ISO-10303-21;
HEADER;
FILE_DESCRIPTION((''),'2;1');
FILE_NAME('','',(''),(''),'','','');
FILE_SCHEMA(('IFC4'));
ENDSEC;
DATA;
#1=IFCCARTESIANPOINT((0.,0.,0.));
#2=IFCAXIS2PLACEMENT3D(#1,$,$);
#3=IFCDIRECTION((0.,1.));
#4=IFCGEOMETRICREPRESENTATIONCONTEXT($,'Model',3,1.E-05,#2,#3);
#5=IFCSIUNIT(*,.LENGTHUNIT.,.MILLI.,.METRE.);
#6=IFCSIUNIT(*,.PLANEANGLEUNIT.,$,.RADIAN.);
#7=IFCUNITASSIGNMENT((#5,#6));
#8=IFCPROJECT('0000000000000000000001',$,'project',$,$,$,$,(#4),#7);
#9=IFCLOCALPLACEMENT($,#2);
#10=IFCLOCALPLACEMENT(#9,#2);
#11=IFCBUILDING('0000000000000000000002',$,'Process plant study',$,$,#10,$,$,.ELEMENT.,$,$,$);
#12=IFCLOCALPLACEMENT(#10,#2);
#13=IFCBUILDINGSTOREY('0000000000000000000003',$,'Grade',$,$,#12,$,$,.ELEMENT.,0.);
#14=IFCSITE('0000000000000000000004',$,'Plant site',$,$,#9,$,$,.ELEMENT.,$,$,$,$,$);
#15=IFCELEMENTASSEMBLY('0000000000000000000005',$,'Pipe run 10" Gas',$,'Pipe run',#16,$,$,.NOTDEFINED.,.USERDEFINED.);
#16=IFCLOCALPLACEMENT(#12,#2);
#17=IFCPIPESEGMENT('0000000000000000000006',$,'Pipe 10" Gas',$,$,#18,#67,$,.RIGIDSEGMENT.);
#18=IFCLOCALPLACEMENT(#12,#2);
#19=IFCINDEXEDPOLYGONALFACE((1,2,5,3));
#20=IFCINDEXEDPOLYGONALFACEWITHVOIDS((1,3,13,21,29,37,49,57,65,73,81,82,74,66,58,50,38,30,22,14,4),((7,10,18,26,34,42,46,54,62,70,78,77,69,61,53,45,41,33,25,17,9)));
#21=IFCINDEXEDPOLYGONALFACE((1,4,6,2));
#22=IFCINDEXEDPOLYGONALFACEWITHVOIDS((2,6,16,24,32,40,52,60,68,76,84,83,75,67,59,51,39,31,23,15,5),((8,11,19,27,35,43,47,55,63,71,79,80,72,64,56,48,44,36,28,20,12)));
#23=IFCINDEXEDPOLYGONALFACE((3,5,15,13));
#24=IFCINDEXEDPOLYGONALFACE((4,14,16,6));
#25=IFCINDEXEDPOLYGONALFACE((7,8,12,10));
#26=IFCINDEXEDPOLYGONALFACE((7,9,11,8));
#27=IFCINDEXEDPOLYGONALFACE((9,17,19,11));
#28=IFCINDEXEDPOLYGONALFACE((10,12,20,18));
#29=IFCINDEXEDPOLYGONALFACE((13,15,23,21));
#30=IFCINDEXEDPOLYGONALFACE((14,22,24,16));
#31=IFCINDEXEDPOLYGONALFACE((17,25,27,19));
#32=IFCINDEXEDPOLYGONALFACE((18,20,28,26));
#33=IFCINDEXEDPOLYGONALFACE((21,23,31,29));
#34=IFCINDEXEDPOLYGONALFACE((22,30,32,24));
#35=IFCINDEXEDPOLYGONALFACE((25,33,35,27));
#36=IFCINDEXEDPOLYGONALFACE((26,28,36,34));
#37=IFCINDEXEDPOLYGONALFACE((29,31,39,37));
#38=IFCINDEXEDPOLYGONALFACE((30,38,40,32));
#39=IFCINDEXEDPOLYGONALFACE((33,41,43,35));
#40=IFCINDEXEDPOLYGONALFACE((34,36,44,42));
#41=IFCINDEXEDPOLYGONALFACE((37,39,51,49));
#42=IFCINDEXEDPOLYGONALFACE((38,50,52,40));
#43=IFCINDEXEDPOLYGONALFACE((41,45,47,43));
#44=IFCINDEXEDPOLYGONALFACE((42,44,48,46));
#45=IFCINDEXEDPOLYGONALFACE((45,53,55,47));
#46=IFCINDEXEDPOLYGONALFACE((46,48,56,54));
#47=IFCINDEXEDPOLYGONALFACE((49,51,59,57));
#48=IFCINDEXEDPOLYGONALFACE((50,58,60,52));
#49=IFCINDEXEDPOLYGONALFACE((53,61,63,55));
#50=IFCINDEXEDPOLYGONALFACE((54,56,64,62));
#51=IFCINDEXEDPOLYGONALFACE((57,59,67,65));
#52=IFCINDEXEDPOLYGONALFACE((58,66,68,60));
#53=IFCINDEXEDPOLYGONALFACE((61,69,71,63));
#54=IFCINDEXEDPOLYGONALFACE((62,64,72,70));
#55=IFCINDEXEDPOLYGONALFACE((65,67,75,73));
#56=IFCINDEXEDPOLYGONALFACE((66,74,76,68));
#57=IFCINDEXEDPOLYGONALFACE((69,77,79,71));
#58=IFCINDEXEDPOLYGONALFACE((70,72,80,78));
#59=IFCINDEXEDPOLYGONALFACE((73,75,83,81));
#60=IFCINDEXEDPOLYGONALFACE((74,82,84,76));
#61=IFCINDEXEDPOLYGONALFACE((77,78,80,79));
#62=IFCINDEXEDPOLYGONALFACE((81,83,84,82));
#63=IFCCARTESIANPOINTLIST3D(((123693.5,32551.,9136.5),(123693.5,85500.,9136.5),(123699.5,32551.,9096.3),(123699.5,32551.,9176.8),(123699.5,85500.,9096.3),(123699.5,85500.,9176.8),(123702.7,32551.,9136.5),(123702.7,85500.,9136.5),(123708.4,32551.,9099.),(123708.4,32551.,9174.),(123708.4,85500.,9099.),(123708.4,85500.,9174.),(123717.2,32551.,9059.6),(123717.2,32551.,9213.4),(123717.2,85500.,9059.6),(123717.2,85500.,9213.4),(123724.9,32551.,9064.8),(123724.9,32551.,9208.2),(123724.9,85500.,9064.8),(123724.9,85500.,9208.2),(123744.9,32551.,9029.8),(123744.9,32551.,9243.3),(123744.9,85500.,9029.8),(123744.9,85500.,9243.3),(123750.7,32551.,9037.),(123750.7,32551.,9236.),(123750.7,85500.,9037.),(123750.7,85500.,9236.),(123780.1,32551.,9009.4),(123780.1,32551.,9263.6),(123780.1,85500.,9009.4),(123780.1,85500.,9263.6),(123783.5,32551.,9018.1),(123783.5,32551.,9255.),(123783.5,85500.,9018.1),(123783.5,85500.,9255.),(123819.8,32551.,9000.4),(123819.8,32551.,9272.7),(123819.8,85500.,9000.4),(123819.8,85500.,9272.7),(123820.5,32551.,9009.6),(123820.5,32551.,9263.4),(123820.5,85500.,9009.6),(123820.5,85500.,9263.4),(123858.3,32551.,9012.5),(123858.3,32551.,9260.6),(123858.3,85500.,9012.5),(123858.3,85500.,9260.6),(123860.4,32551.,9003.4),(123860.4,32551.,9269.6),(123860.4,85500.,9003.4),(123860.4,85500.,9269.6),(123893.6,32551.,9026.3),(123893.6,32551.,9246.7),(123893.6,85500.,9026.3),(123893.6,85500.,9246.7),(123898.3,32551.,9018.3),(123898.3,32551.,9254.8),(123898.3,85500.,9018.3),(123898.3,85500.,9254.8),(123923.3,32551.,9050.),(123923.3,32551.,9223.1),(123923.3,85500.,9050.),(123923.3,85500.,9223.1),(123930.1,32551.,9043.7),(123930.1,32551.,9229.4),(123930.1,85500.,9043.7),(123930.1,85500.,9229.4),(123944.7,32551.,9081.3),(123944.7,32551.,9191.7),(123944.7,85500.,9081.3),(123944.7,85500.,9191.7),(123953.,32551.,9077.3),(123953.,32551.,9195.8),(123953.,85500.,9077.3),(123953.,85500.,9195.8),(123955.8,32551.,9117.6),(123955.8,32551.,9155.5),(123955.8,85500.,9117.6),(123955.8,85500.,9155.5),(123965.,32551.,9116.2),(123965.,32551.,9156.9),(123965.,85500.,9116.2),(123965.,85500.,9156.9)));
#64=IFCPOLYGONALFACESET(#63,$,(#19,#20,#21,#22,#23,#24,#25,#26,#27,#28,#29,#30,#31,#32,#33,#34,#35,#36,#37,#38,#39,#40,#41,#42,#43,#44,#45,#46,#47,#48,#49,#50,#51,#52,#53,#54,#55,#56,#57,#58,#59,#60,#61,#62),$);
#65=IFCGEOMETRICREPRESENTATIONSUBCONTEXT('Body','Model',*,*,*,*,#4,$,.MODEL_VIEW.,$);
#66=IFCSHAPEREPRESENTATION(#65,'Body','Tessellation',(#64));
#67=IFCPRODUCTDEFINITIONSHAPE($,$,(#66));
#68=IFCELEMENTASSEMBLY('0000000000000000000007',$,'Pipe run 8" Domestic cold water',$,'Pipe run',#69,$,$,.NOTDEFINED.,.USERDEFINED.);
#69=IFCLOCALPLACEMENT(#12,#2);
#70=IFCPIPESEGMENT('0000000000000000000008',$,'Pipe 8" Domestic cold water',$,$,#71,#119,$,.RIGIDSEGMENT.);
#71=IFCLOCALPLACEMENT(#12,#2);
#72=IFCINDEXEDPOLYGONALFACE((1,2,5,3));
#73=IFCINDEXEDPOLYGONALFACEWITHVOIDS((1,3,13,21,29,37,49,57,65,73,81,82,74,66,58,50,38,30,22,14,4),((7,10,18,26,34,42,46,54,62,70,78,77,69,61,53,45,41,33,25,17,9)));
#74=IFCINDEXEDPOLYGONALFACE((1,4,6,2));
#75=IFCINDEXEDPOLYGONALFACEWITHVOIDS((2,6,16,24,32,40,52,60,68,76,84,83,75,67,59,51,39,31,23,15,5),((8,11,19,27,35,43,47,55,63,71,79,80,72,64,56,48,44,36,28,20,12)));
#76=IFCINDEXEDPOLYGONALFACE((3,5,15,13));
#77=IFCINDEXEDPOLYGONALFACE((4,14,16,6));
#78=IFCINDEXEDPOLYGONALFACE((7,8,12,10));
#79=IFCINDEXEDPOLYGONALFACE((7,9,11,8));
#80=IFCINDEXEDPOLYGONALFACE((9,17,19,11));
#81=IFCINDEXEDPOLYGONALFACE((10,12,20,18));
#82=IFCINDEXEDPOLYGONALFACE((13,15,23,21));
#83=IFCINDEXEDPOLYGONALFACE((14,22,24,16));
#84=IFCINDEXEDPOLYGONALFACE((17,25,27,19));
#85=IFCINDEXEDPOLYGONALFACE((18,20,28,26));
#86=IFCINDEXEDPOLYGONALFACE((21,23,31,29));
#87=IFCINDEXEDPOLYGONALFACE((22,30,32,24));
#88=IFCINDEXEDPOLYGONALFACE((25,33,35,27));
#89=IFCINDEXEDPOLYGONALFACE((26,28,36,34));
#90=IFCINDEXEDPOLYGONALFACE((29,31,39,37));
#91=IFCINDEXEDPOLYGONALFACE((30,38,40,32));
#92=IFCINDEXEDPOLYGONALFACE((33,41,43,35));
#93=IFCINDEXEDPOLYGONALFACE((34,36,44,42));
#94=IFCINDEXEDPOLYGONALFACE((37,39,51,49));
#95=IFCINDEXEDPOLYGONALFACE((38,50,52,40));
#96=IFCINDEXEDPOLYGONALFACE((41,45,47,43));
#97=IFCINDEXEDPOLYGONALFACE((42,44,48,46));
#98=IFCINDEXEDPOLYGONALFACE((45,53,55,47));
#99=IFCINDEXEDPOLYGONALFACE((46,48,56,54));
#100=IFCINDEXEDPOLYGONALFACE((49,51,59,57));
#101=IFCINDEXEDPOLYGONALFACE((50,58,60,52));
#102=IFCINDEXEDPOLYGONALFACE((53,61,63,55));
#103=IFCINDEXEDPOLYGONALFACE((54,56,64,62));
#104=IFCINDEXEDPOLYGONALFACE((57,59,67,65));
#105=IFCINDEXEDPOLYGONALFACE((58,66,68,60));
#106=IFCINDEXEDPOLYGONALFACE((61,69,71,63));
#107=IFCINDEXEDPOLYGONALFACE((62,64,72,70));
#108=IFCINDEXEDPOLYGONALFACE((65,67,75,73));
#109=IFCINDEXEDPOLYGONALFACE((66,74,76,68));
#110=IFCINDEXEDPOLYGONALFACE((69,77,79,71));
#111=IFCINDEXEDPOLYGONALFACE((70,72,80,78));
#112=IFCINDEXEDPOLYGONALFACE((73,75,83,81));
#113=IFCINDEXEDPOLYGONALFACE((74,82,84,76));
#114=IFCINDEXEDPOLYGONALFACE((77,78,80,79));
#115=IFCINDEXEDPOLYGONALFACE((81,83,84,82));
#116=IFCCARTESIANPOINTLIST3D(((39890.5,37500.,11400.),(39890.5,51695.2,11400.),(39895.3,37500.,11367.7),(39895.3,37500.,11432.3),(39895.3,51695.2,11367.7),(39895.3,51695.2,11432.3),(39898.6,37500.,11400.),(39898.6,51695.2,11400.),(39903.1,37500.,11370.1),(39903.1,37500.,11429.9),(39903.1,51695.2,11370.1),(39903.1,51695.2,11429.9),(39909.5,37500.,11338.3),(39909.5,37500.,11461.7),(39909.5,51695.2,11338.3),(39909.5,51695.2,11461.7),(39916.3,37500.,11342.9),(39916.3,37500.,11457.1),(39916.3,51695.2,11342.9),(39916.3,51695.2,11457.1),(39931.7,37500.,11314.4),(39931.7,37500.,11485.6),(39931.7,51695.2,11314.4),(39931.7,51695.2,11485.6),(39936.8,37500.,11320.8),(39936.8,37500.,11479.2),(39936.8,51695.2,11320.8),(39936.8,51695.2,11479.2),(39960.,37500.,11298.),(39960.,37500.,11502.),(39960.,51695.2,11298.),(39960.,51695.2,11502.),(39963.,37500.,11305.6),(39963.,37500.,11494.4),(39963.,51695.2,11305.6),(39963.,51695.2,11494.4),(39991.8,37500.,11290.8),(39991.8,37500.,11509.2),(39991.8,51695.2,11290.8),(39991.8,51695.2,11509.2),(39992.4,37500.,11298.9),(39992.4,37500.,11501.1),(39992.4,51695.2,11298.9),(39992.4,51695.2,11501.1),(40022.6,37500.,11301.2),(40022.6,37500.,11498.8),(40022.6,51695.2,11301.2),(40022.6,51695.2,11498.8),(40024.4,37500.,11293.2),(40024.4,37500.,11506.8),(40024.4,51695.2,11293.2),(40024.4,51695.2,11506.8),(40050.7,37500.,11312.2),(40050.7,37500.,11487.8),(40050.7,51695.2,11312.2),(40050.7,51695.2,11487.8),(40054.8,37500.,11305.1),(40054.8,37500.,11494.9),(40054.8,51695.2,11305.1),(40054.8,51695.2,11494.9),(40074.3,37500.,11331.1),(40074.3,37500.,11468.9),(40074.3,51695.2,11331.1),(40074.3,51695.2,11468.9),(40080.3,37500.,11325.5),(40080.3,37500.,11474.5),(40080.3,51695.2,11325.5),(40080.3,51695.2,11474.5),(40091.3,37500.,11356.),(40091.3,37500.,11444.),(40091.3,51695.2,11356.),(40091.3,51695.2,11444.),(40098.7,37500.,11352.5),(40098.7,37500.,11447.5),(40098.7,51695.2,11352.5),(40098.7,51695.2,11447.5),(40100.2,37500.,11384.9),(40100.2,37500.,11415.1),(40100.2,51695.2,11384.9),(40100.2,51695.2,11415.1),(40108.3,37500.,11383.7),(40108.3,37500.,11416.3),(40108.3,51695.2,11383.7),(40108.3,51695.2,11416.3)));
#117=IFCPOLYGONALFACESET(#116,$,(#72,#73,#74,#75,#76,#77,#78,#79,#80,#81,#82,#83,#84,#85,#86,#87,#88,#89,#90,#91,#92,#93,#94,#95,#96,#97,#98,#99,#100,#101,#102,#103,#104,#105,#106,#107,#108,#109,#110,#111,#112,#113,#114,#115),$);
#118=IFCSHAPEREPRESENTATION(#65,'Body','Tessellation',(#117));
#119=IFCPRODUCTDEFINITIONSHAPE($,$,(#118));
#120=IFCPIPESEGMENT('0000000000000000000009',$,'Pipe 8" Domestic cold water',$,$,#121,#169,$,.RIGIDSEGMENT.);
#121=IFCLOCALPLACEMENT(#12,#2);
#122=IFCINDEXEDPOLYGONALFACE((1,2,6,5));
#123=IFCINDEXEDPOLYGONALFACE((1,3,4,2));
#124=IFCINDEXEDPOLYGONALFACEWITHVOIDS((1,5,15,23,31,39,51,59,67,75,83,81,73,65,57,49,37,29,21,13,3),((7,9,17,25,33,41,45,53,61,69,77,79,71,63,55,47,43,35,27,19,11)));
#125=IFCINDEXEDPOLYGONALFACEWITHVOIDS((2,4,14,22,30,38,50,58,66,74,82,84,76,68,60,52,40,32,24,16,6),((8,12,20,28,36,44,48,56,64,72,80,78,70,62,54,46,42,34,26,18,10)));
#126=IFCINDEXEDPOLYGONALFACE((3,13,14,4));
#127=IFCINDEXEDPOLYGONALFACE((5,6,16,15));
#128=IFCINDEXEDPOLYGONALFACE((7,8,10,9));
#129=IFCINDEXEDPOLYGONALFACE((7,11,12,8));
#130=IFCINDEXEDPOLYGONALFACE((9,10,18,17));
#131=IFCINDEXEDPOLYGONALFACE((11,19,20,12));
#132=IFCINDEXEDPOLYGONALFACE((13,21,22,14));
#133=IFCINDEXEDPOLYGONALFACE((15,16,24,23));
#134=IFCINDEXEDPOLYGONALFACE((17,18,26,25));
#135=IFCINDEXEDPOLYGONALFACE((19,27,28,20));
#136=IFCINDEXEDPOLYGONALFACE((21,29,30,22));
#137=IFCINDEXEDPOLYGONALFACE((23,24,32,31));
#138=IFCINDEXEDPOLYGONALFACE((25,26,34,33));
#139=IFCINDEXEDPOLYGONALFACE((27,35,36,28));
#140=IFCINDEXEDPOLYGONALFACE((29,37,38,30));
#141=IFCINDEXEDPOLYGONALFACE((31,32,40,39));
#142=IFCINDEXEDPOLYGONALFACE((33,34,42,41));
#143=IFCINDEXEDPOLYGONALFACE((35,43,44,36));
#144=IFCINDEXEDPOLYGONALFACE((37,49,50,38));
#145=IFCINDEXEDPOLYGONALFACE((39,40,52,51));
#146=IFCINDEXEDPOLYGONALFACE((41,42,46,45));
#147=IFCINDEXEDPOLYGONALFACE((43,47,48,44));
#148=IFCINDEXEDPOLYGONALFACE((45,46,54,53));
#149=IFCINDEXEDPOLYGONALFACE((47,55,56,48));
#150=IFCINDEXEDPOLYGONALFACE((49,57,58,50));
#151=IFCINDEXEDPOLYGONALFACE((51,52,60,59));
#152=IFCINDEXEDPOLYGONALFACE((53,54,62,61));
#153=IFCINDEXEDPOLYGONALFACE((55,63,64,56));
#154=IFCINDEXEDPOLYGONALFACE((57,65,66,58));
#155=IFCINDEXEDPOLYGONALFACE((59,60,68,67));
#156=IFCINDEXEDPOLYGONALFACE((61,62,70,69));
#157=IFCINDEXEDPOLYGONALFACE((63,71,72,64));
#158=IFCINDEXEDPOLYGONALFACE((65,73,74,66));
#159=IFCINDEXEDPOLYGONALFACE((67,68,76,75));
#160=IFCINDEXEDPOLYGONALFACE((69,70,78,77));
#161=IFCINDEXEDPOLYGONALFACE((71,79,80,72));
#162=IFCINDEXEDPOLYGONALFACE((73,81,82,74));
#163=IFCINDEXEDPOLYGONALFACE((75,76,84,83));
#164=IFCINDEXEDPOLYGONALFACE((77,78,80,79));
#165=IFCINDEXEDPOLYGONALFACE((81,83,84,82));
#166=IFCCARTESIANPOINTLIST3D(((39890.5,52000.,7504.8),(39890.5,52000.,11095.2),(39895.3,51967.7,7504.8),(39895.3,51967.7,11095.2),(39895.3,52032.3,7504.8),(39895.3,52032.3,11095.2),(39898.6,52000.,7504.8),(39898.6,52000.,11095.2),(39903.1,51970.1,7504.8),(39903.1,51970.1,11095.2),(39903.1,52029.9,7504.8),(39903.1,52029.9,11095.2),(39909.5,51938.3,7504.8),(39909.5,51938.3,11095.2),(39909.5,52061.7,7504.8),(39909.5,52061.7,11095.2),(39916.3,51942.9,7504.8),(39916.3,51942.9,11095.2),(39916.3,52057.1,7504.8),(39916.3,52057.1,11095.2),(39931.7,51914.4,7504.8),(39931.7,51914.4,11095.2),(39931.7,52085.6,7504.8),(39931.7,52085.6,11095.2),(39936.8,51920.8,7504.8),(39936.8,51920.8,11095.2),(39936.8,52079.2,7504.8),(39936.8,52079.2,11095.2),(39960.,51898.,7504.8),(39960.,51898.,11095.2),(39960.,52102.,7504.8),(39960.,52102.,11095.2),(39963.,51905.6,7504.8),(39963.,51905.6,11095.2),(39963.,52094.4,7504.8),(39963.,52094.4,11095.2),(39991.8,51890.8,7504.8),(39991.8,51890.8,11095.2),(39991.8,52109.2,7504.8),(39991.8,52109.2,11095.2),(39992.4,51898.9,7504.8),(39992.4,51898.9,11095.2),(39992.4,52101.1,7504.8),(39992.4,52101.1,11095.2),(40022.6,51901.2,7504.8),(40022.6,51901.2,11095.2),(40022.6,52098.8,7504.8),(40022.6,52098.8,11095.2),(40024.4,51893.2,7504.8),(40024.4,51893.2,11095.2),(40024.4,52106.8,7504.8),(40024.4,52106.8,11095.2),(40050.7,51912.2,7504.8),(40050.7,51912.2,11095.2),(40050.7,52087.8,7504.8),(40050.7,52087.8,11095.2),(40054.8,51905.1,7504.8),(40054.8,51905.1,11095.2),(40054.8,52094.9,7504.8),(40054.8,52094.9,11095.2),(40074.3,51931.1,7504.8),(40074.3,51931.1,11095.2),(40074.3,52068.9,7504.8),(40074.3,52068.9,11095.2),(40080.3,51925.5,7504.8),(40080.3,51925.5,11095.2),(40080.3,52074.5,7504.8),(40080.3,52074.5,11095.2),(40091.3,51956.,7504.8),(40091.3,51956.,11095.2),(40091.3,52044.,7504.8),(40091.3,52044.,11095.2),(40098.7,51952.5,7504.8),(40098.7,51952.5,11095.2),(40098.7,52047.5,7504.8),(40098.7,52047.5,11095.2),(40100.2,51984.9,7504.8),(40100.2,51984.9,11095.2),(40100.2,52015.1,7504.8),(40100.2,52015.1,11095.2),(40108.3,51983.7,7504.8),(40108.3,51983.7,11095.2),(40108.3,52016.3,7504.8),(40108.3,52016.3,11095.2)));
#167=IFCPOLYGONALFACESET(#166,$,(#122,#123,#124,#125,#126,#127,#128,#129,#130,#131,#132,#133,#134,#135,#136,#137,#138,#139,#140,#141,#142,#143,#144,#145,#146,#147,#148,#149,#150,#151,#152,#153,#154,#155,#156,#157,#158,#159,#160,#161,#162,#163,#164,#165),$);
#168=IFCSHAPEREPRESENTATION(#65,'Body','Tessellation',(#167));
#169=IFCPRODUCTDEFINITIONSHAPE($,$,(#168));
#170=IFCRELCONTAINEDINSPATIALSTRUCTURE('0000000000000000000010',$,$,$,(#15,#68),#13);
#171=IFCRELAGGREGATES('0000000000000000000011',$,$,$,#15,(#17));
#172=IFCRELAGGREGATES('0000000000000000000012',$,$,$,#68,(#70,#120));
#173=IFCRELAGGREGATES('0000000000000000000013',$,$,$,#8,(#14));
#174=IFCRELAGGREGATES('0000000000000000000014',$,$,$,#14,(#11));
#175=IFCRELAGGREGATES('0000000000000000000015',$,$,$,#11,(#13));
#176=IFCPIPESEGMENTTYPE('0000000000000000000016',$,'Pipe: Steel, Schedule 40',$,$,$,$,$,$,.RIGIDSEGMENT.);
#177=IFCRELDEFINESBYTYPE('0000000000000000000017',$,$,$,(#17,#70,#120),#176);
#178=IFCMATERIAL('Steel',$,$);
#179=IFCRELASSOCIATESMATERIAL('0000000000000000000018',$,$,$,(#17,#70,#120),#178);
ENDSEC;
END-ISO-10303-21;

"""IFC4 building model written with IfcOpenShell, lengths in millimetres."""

from ifc_helpers import new_model, si_unit, direction, frame, origin, origin_with_axes, origin_2d, place, context, subcontext, project, spatial, hollow_circle, extrude, material, type_object, element, aggregate, save


model = new_model("IFC4")

# Units and contexts
model_context = context("Model", 3, precision=1e-05, world=origin(), true_north=direction((0.0, 1.0)))
body_context = subcontext(model_context, "Body", "Model", "MODEL_VIEW")
ifc_project = project(units=[si_unit("LENGTHUNIT", "METRE", prefix="MILLI"), si_unit("PLANEANGLEUNIT", "RADIAN")], contexts=[model_context])

# Site, building, storey
site_placement = place(None, origin())
site = spatial("IfcSite", under=ifc_project, at=site_placement, Name="Plant site", CompositionType="ELEMENT")
building_placement = place(site_placement, origin())
building = spatial("IfcBuilding", under=site, at=building_placement, Name="Process plant study", CompositionType="ELEMENT")
storey_placement = place(building_placement, origin())
storey = spatial("IfcBuildingStorey", under=building, at=storey_placement, Name="Grade", CompositionType="ELEMENT", Elevation=0.0)

# Element assembly, pipe segment
assembly_1_placement = place(storey_placement, origin_with_axes())
assembly_1 = element("IfcElementAssembly", 1, at=assembly_1_placement, inside=storey, Name="Pipe run 10\" Gas", ObjectType="Pipe run", AssemblyPlace="NOTDEFINED", PredefinedType="USERDEFINED")
ifc_material = material(Name="Steel")
pipe_segment_type = type_object("IfcPipeSegmentType", Name="Pipe: Steel, Schedule 40", PredefinedType="RIGIDSEGMENT")
pipe_segment_1_placement = place(storey_placement, origin_with_axes())
pipe_segment_1 = element("IfcPipeSegment", 2, at=pipe_segment_1_placement, type_object=pipe_segment_type, material=ifc_material, Name="Pipe 10\" Gas", PredefinedType="RIGIDSEGMENT", context=body_context, shape_type="SweptSolid", body=[
    extrude(hollow_circle(Radius=136.5, WallThickness=9.3, at=origin_2d()), frame((123830.0, 32551.0, 9136.5), z_axis=(0.0, 1.0, 0.0), x_axis=(-1.0, 0.0, 0.0)), (0.0, 0.0, 1.0), 52949.0),
])

# Element assembly, pipe segments
assembly_2_placement = place(storey_placement, origin_with_axes())
assembly_2 = element("IfcElementAssembly", 3, at=assembly_2_placement, inside=storey, Name="Pipe run 8\" Domestic cold water", ObjectType="Pipe run", AssemblyPlace="NOTDEFINED", PredefinedType="USERDEFINED")
pipe_segment_2_placement = place(storey_placement, origin_with_axes())
pipe_segment_2 = element("IfcPipeSegment", 4, at=pipe_segment_2_placement, type_object=pipe_segment_type, material=ifc_material, Name="Pipe 8\" Domestic cold water", PredefinedType="RIGIDSEGMENT", context=body_context, shape_type="SweptSolid", body=[
    extrude(hollow_circle(Radius=109.5, WallThickness=8.2, at=origin_2d()), frame((40000.0, 37500.0, 11400.0), z_axis=(0.0, 1.0, 0.0), x_axis=(-1.0, 0.0, 0.0)), (0.0, 0.0, 1.0), 14195.2),
])
pipe_segment_3_placement = place(storey_placement, origin_with_axes())
pipe_segment_3 = element("IfcPipeSegment", 5, at=pipe_segment_3_placement, type_object=pipe_segment_type, material=ifc_material, Name="Pipe 8\" Domestic cold water", PredefinedType="RIGIDSEGMENT", context=body_context, shape_type="SweptSolid", body=[
    extrude(hollow_circle(Radius=109.5, WallThickness=8.2, at=origin_2d()), frame((40000.0, 52000.0, 11095.2), z_axis=(0.0, 0.0, -1.0), x_axis=(-1.0, 0.0, 0.0)), (0.0, 0.0, 1.0), 3590.4),
])

aggregate(assembly_1, [pipe_segment_1])
aggregate(assembly_2, [pipe_segment_2, pipe_segment_3])

save(model, "model.ifc")
